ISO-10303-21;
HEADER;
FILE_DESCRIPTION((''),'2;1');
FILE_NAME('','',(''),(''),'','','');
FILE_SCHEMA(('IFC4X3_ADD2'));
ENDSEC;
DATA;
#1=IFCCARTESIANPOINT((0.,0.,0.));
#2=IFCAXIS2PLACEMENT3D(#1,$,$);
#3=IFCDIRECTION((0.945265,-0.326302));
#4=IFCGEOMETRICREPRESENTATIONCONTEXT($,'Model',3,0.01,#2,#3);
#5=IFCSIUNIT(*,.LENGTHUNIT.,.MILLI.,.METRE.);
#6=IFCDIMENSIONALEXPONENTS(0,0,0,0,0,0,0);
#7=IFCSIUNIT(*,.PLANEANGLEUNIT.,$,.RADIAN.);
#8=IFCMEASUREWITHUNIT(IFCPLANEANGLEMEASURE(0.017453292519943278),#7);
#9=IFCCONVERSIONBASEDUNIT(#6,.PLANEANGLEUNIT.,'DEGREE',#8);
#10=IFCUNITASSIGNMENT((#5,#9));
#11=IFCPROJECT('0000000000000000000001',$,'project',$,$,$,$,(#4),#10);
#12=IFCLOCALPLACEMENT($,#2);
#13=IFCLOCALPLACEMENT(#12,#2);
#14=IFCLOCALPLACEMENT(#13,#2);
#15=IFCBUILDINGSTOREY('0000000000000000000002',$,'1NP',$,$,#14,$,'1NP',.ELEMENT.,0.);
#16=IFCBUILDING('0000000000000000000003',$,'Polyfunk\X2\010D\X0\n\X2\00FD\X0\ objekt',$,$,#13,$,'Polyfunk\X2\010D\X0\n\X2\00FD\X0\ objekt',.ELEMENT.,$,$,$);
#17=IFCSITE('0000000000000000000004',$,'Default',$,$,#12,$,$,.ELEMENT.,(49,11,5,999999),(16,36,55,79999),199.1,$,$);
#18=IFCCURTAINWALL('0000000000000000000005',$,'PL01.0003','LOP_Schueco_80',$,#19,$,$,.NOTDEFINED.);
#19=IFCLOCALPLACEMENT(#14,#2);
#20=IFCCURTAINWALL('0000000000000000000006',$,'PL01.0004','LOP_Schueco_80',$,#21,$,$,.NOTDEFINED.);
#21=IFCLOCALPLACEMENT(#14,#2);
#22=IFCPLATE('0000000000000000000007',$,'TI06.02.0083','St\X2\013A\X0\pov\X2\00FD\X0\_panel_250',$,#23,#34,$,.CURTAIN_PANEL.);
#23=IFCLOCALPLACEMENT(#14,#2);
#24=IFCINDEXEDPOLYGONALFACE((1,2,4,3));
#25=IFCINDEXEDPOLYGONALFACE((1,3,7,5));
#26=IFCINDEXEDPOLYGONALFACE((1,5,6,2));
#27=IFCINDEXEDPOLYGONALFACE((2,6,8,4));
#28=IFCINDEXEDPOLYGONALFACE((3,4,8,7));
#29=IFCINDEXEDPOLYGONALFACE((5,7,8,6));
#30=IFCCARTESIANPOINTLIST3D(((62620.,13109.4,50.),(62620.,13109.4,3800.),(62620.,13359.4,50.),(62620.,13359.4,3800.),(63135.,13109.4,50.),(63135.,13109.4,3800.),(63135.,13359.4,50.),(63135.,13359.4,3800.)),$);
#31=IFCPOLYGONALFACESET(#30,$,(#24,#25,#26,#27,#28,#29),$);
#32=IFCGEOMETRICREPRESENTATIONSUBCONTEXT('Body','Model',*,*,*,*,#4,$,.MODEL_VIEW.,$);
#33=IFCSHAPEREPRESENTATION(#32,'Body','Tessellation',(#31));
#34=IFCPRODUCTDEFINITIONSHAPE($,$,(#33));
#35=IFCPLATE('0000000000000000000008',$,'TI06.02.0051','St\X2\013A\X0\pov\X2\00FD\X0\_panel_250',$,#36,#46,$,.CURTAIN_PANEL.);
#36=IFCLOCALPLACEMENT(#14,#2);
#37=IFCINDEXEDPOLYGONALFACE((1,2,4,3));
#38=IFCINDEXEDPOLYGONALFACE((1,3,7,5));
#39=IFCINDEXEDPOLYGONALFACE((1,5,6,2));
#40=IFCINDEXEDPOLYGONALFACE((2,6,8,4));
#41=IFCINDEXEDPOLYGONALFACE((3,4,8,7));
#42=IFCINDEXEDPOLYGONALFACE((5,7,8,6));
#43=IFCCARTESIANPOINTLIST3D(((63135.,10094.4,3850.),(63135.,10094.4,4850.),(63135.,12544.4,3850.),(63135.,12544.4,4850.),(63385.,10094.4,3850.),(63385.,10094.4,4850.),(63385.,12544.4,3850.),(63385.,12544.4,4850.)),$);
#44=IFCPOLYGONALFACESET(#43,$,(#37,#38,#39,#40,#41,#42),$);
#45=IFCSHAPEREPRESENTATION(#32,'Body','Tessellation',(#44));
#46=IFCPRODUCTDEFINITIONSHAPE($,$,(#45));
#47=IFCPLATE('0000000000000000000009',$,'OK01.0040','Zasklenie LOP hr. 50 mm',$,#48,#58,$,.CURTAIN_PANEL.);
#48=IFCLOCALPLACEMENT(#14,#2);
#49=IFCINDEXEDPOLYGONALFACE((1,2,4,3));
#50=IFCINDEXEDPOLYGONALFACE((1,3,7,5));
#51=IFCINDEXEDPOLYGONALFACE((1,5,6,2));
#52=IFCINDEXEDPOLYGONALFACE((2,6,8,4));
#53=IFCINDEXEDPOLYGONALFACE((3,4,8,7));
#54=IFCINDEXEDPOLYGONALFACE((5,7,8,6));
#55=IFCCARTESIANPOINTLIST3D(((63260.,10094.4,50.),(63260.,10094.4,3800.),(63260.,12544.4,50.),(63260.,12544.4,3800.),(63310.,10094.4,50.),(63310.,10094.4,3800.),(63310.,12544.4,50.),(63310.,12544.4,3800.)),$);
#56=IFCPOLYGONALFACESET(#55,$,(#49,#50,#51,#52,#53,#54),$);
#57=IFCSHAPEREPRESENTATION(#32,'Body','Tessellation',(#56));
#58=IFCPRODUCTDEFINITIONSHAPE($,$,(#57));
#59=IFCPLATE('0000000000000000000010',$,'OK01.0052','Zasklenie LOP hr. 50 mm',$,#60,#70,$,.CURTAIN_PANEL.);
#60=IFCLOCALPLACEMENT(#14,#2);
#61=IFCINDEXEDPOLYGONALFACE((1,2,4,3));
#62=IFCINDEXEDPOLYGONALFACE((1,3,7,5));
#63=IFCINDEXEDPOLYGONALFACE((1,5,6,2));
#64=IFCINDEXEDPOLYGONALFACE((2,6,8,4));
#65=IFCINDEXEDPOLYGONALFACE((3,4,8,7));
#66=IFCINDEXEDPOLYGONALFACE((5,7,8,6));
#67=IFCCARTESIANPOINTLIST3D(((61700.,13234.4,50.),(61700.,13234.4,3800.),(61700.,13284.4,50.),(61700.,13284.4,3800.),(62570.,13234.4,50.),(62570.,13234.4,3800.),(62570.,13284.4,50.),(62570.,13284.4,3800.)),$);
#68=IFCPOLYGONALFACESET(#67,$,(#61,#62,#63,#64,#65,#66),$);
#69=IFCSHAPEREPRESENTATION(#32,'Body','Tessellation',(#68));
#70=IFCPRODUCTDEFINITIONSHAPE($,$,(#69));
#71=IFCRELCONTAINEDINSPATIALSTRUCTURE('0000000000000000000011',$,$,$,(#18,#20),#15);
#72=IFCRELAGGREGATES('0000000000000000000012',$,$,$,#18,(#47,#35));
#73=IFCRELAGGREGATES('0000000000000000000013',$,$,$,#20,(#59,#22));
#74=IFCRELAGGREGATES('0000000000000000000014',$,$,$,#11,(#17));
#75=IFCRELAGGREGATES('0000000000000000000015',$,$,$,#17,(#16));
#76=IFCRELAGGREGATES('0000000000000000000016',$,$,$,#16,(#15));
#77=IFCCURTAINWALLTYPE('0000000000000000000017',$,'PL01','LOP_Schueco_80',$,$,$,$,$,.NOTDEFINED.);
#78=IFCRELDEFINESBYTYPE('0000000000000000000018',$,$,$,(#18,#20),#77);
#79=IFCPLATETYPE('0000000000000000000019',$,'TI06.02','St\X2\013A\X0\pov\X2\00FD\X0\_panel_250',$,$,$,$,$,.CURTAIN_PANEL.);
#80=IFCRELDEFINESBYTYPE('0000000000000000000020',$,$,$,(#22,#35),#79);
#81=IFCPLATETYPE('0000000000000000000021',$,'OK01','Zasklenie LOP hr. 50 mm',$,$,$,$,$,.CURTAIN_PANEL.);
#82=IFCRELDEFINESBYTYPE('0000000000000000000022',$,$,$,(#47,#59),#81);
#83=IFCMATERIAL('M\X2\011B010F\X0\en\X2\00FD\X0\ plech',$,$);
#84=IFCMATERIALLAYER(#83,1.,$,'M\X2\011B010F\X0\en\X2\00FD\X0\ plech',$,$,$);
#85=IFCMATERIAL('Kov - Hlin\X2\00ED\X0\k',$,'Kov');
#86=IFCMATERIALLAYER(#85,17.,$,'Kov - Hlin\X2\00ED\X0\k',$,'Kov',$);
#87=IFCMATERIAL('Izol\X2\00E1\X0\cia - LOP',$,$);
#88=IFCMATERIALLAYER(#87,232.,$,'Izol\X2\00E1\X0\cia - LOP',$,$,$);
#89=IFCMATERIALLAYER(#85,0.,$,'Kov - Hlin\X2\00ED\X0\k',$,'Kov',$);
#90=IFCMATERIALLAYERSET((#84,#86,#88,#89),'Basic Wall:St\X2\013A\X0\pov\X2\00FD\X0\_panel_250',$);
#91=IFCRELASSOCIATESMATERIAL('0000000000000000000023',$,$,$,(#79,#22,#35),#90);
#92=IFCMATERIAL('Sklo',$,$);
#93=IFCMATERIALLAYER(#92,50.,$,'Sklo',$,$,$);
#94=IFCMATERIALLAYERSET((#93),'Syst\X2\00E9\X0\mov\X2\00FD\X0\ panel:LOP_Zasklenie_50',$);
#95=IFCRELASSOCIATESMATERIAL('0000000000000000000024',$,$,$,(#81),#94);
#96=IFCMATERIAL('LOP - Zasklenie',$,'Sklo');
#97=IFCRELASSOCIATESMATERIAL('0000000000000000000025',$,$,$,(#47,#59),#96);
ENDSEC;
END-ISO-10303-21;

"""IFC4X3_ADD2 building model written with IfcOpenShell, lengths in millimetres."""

from ifc_helpers import new_model, entity, si_unit, converted_unit, direction, frame, frame_2d, origin, place, context, subcontext, project, spatial, rectangle, extrude, source, transform, mapped, material, layer, layer_set, layer_usage, type_object, type_shapes, element, aggregate, save


model = new_model("IFC4X3_ADD2")

# Units and contexts
model_context = context("Model", 3, precision=0.01, world=origin(), true_north=direction((0.945265, -0.326302)))
body_context = subcontext(model_context, "Body", "Model", "MODEL_VIEW")
ifc_project = project(units=[si_unit("LENGTHUNIT", "METRE", prefix="MILLI"), converted_unit("PLANEANGLEUNIT", "DEGREE", entity("IfcPlaneAngleMeasure", 0.017453292519943278), si_unit("PLANEANGLEUNIT", "RADIAN"), dimensions=[0, 0, 0, 0, 0, 0, 0])], contexts=[model_context])

# Site, building, storey
site_placement = place(None, origin())
site = spatial("IfcSite", under=ifc_project, at=site_placement, Name="Default", CompositionType="ELEMENT", RefLatitude=(49, 11, 5, 999999), RefLongitude=(16, 36, 55, 79999), RefElevation=199.1)
building_placement = place(site_placement, origin())
building = spatial("IfcBuilding", under=site, at=building_placement, Name="Polyfunkčný objekt", LongName="Polyfunkčný objekt", CompositionType="ELEMENT")
storey_placement = place(building_placement, origin())
storey = spatial("IfcBuildingStorey", under=building, at=storey_placement, Name="1NP", LongName="1NP", CompositionType="ELEMENT", Elevation=0.0)

# Curtain walls
curtain_wall_type = type_object("IfcCurtainWallType", Name="PL01", Description="LOP_Schueco_80", PredefinedType="NOTDEFINED")
curtain_wall_1_placement = place(storey_placement, origin())
curtain_wall_1 = element("IfcCurtainWall", 1, at=curtain_wall_1_placement, inside=storey, type_object=curtain_wall_type, Name="PL01.0003", Description="LOP_Schueco_80", PredefinedType="NOTDEFINED")
curtain_wall_2_placement = place(storey_placement, origin())
curtain_wall_2 = element("IfcCurtainWall", 2, at=curtain_wall_2_placement, inside=storey, type_object=curtain_wall_type, Name="PL01.0004", Description="LOP_Schueco_80", PredefinedType="NOTDEFINED")

# Plates
ifc_material_1 = material(Name="Měďený plech")
ifc_layer_1 = layer(ifc_material_1, 1.0, Name="Měďený plech")
ifc_material_2 = material(Name="Kov - Hliník", Category="Kov")
ifc_layer_2 = layer(ifc_material_2, 17.0, Name="Kov - Hliník", Category="Kov")
ifc_material_3 = material(Name="Izolácia - LOP")
ifc_layer_3 = layer(ifc_material_3, 232.0, Name="Izolácia - LOP")
ifc_layer_4 = layer(ifc_material_2, 0.0, Name="Kov - Hliník", Category="Kov")
ifc_layer_set_1 = layer_set([ifc_layer_1, ifc_layer_2, ifc_layer_3, ifc_layer_4], Name="Basic Wall:Stĺpový_panel_250")
ifc_layer_usage_1 = layer_usage(ifc_layer_set_1, "AXIS2", "NEGATIVE", 125.0)
plate_type_1 = type_object("IfcPlateType", Name="TI06.02", Description="Stĺpový_panel_250", PredefinedType="CURTAIN_PANEL", material=ifc_layer_set_1)
plate_1_placement = place(storey_placement, frame((62620.0, 13234.4, 50.0)))
plate_1 = element("IfcPlate", 3, at=plate_1_placement, type_object=plate_type_1, material=ifc_layer_usage_1, Name="TI06.02.0083", Description="Stĺpový_panel_250", PredefinedType="CURTAIN_PANEL", context=body_context, shape_type="SweptSolid", body=[
    extrude(rectangle(XDim=250.0, YDim=515.0, at=frame_2d((0.0, 0.0), x_axis=(1.0, 0.0))), frame((257.5, 0.0, 0.0), z_axis=(0.0, 0.0, 1.0), x_axis=(0.0, 1.0, 0.0)), (0.0, 0.0, 1.0), 3750.0),
])
ifc_layer_usage_2 = layer_usage(ifc_layer_set_1, "AXIS2", "NEGATIVE", 125.0)
plate_2_placement = place(storey_placement, frame((63260.0, 12544.4, 3850.0), z_axis=(0.0, 0.0, 1.0), x_axis=(0.0, -1.0, 0.0)))
plate_2 = element("IfcPlate", 4, at=plate_2_placement, type_object=plate_type_1, material=ifc_layer_usage_2, Name="TI06.02.0051", Description="Stĺpový_panel_250", PredefinedType="CURTAIN_PANEL", context=body_context, shape_type="SweptSolid", body=[
    extrude(rectangle(XDim=250.0, YDim=2450.0, at=frame_2d((0.0, 0.0), x_axis=(1.0, 0.0))), frame((1225.0, 0.0, 0.0), z_axis=(0.0, 0.0, 1.0), x_axis=(0.0, 1.0, 0.0)), (0.0, 0.0, 1.0), 1000.0),
])
ifc_material_4 = material(Name="LOP - Zasklenie", Category="Sklo")
ifc_material_5 = material(Name="Sklo")
ifc_layer_5 = layer(ifc_material_5, 50.0, Name="Sklo")
ifc_layer_set_2 = layer_set([ifc_layer_5], Name="Systémový panel:LOP_Zasklenie_50")
plate_type_2 = type_object("IfcPlateType", Name="OK01", Description="Zasklenie LOP hr. 50 mm", PredefinedType="CURTAIN_PANEL", material=ifc_layer_set_2)
shared_shape_1 = source(origin(), body_context, "Body", "SweptSolid", [
    extrude(rectangle(XDim=3750.0, YDim=2450.0, at=frame_2d((-141.7, 0.0), x_axis=(1.0, 0.0))), frame((0.0, 0.0, 2016.7), z_axis=(0.0, 1.0, 0.0), x_axis=(0.0, 0.0, 1.0)), (0.0, 0.0, 1.0), 50.0),
])
plate_3_placement = place(curtain_wall_1_placement, frame((63260.0, 11319.4, 50.0), z_axis=(0.0, 0.0, 1.0), x_axis=(0.0, -1.0, 0.0)))
plate_3 = element("IfcPlate", 5, at=plate_3_placement, type_object=plate_type_2, material=ifc_material_4, Name="OK01.0040", Description="Zasklenie LOP hr. 50 mm", PredefinedType="CURTAIN_PANEL", context=body_context, shape_type="MappedRepresentation", body=[
    mapped(shared_shape_1, transform((0.0, 0.0, 0.0), scale=1.0)),
])
aggregate(curtain_wall_1, [plate_3, plate_2])
shared_shape_2 = source(origin(), body_context, "Body", "SweptSolid", [
    extrude(rectangle(XDim=3750.0, YDim=870.0, at=frame_2d((-141.7, 0.0), x_axis=(1.0, 0.0))), frame((0.0, 0.0, 2016.7), z_axis=(0.0, 1.0, 0.0), x_axis=(0.0, 0.0, 1.0)), (0.0, 0.0, 1.0), 50.0),
])
type_shapes(plate_type_2, [shared_shape_1, shared_shape_2])
plate_4_placement = place(curtain_wall_2_placement, frame((62135.0, 13234.4, 50.0)))
plate_4 = element("IfcPlate", 6, at=plate_4_placement, type_object=plate_type_2, material=ifc_material_4, Name="OK01.0052", Description="Zasklenie LOP hr. 50 mm", PredefinedType="CURTAIN_PANEL", context=body_context, shape_type="MappedRepresentation", body=[
    mapped(shared_shape_2, transform((0.0, 0.0, 0.0), scale=1.0)),
])
aggregate(curtain_wall_2, [plate_4, plate_1])

save(model, "model.ifc")
